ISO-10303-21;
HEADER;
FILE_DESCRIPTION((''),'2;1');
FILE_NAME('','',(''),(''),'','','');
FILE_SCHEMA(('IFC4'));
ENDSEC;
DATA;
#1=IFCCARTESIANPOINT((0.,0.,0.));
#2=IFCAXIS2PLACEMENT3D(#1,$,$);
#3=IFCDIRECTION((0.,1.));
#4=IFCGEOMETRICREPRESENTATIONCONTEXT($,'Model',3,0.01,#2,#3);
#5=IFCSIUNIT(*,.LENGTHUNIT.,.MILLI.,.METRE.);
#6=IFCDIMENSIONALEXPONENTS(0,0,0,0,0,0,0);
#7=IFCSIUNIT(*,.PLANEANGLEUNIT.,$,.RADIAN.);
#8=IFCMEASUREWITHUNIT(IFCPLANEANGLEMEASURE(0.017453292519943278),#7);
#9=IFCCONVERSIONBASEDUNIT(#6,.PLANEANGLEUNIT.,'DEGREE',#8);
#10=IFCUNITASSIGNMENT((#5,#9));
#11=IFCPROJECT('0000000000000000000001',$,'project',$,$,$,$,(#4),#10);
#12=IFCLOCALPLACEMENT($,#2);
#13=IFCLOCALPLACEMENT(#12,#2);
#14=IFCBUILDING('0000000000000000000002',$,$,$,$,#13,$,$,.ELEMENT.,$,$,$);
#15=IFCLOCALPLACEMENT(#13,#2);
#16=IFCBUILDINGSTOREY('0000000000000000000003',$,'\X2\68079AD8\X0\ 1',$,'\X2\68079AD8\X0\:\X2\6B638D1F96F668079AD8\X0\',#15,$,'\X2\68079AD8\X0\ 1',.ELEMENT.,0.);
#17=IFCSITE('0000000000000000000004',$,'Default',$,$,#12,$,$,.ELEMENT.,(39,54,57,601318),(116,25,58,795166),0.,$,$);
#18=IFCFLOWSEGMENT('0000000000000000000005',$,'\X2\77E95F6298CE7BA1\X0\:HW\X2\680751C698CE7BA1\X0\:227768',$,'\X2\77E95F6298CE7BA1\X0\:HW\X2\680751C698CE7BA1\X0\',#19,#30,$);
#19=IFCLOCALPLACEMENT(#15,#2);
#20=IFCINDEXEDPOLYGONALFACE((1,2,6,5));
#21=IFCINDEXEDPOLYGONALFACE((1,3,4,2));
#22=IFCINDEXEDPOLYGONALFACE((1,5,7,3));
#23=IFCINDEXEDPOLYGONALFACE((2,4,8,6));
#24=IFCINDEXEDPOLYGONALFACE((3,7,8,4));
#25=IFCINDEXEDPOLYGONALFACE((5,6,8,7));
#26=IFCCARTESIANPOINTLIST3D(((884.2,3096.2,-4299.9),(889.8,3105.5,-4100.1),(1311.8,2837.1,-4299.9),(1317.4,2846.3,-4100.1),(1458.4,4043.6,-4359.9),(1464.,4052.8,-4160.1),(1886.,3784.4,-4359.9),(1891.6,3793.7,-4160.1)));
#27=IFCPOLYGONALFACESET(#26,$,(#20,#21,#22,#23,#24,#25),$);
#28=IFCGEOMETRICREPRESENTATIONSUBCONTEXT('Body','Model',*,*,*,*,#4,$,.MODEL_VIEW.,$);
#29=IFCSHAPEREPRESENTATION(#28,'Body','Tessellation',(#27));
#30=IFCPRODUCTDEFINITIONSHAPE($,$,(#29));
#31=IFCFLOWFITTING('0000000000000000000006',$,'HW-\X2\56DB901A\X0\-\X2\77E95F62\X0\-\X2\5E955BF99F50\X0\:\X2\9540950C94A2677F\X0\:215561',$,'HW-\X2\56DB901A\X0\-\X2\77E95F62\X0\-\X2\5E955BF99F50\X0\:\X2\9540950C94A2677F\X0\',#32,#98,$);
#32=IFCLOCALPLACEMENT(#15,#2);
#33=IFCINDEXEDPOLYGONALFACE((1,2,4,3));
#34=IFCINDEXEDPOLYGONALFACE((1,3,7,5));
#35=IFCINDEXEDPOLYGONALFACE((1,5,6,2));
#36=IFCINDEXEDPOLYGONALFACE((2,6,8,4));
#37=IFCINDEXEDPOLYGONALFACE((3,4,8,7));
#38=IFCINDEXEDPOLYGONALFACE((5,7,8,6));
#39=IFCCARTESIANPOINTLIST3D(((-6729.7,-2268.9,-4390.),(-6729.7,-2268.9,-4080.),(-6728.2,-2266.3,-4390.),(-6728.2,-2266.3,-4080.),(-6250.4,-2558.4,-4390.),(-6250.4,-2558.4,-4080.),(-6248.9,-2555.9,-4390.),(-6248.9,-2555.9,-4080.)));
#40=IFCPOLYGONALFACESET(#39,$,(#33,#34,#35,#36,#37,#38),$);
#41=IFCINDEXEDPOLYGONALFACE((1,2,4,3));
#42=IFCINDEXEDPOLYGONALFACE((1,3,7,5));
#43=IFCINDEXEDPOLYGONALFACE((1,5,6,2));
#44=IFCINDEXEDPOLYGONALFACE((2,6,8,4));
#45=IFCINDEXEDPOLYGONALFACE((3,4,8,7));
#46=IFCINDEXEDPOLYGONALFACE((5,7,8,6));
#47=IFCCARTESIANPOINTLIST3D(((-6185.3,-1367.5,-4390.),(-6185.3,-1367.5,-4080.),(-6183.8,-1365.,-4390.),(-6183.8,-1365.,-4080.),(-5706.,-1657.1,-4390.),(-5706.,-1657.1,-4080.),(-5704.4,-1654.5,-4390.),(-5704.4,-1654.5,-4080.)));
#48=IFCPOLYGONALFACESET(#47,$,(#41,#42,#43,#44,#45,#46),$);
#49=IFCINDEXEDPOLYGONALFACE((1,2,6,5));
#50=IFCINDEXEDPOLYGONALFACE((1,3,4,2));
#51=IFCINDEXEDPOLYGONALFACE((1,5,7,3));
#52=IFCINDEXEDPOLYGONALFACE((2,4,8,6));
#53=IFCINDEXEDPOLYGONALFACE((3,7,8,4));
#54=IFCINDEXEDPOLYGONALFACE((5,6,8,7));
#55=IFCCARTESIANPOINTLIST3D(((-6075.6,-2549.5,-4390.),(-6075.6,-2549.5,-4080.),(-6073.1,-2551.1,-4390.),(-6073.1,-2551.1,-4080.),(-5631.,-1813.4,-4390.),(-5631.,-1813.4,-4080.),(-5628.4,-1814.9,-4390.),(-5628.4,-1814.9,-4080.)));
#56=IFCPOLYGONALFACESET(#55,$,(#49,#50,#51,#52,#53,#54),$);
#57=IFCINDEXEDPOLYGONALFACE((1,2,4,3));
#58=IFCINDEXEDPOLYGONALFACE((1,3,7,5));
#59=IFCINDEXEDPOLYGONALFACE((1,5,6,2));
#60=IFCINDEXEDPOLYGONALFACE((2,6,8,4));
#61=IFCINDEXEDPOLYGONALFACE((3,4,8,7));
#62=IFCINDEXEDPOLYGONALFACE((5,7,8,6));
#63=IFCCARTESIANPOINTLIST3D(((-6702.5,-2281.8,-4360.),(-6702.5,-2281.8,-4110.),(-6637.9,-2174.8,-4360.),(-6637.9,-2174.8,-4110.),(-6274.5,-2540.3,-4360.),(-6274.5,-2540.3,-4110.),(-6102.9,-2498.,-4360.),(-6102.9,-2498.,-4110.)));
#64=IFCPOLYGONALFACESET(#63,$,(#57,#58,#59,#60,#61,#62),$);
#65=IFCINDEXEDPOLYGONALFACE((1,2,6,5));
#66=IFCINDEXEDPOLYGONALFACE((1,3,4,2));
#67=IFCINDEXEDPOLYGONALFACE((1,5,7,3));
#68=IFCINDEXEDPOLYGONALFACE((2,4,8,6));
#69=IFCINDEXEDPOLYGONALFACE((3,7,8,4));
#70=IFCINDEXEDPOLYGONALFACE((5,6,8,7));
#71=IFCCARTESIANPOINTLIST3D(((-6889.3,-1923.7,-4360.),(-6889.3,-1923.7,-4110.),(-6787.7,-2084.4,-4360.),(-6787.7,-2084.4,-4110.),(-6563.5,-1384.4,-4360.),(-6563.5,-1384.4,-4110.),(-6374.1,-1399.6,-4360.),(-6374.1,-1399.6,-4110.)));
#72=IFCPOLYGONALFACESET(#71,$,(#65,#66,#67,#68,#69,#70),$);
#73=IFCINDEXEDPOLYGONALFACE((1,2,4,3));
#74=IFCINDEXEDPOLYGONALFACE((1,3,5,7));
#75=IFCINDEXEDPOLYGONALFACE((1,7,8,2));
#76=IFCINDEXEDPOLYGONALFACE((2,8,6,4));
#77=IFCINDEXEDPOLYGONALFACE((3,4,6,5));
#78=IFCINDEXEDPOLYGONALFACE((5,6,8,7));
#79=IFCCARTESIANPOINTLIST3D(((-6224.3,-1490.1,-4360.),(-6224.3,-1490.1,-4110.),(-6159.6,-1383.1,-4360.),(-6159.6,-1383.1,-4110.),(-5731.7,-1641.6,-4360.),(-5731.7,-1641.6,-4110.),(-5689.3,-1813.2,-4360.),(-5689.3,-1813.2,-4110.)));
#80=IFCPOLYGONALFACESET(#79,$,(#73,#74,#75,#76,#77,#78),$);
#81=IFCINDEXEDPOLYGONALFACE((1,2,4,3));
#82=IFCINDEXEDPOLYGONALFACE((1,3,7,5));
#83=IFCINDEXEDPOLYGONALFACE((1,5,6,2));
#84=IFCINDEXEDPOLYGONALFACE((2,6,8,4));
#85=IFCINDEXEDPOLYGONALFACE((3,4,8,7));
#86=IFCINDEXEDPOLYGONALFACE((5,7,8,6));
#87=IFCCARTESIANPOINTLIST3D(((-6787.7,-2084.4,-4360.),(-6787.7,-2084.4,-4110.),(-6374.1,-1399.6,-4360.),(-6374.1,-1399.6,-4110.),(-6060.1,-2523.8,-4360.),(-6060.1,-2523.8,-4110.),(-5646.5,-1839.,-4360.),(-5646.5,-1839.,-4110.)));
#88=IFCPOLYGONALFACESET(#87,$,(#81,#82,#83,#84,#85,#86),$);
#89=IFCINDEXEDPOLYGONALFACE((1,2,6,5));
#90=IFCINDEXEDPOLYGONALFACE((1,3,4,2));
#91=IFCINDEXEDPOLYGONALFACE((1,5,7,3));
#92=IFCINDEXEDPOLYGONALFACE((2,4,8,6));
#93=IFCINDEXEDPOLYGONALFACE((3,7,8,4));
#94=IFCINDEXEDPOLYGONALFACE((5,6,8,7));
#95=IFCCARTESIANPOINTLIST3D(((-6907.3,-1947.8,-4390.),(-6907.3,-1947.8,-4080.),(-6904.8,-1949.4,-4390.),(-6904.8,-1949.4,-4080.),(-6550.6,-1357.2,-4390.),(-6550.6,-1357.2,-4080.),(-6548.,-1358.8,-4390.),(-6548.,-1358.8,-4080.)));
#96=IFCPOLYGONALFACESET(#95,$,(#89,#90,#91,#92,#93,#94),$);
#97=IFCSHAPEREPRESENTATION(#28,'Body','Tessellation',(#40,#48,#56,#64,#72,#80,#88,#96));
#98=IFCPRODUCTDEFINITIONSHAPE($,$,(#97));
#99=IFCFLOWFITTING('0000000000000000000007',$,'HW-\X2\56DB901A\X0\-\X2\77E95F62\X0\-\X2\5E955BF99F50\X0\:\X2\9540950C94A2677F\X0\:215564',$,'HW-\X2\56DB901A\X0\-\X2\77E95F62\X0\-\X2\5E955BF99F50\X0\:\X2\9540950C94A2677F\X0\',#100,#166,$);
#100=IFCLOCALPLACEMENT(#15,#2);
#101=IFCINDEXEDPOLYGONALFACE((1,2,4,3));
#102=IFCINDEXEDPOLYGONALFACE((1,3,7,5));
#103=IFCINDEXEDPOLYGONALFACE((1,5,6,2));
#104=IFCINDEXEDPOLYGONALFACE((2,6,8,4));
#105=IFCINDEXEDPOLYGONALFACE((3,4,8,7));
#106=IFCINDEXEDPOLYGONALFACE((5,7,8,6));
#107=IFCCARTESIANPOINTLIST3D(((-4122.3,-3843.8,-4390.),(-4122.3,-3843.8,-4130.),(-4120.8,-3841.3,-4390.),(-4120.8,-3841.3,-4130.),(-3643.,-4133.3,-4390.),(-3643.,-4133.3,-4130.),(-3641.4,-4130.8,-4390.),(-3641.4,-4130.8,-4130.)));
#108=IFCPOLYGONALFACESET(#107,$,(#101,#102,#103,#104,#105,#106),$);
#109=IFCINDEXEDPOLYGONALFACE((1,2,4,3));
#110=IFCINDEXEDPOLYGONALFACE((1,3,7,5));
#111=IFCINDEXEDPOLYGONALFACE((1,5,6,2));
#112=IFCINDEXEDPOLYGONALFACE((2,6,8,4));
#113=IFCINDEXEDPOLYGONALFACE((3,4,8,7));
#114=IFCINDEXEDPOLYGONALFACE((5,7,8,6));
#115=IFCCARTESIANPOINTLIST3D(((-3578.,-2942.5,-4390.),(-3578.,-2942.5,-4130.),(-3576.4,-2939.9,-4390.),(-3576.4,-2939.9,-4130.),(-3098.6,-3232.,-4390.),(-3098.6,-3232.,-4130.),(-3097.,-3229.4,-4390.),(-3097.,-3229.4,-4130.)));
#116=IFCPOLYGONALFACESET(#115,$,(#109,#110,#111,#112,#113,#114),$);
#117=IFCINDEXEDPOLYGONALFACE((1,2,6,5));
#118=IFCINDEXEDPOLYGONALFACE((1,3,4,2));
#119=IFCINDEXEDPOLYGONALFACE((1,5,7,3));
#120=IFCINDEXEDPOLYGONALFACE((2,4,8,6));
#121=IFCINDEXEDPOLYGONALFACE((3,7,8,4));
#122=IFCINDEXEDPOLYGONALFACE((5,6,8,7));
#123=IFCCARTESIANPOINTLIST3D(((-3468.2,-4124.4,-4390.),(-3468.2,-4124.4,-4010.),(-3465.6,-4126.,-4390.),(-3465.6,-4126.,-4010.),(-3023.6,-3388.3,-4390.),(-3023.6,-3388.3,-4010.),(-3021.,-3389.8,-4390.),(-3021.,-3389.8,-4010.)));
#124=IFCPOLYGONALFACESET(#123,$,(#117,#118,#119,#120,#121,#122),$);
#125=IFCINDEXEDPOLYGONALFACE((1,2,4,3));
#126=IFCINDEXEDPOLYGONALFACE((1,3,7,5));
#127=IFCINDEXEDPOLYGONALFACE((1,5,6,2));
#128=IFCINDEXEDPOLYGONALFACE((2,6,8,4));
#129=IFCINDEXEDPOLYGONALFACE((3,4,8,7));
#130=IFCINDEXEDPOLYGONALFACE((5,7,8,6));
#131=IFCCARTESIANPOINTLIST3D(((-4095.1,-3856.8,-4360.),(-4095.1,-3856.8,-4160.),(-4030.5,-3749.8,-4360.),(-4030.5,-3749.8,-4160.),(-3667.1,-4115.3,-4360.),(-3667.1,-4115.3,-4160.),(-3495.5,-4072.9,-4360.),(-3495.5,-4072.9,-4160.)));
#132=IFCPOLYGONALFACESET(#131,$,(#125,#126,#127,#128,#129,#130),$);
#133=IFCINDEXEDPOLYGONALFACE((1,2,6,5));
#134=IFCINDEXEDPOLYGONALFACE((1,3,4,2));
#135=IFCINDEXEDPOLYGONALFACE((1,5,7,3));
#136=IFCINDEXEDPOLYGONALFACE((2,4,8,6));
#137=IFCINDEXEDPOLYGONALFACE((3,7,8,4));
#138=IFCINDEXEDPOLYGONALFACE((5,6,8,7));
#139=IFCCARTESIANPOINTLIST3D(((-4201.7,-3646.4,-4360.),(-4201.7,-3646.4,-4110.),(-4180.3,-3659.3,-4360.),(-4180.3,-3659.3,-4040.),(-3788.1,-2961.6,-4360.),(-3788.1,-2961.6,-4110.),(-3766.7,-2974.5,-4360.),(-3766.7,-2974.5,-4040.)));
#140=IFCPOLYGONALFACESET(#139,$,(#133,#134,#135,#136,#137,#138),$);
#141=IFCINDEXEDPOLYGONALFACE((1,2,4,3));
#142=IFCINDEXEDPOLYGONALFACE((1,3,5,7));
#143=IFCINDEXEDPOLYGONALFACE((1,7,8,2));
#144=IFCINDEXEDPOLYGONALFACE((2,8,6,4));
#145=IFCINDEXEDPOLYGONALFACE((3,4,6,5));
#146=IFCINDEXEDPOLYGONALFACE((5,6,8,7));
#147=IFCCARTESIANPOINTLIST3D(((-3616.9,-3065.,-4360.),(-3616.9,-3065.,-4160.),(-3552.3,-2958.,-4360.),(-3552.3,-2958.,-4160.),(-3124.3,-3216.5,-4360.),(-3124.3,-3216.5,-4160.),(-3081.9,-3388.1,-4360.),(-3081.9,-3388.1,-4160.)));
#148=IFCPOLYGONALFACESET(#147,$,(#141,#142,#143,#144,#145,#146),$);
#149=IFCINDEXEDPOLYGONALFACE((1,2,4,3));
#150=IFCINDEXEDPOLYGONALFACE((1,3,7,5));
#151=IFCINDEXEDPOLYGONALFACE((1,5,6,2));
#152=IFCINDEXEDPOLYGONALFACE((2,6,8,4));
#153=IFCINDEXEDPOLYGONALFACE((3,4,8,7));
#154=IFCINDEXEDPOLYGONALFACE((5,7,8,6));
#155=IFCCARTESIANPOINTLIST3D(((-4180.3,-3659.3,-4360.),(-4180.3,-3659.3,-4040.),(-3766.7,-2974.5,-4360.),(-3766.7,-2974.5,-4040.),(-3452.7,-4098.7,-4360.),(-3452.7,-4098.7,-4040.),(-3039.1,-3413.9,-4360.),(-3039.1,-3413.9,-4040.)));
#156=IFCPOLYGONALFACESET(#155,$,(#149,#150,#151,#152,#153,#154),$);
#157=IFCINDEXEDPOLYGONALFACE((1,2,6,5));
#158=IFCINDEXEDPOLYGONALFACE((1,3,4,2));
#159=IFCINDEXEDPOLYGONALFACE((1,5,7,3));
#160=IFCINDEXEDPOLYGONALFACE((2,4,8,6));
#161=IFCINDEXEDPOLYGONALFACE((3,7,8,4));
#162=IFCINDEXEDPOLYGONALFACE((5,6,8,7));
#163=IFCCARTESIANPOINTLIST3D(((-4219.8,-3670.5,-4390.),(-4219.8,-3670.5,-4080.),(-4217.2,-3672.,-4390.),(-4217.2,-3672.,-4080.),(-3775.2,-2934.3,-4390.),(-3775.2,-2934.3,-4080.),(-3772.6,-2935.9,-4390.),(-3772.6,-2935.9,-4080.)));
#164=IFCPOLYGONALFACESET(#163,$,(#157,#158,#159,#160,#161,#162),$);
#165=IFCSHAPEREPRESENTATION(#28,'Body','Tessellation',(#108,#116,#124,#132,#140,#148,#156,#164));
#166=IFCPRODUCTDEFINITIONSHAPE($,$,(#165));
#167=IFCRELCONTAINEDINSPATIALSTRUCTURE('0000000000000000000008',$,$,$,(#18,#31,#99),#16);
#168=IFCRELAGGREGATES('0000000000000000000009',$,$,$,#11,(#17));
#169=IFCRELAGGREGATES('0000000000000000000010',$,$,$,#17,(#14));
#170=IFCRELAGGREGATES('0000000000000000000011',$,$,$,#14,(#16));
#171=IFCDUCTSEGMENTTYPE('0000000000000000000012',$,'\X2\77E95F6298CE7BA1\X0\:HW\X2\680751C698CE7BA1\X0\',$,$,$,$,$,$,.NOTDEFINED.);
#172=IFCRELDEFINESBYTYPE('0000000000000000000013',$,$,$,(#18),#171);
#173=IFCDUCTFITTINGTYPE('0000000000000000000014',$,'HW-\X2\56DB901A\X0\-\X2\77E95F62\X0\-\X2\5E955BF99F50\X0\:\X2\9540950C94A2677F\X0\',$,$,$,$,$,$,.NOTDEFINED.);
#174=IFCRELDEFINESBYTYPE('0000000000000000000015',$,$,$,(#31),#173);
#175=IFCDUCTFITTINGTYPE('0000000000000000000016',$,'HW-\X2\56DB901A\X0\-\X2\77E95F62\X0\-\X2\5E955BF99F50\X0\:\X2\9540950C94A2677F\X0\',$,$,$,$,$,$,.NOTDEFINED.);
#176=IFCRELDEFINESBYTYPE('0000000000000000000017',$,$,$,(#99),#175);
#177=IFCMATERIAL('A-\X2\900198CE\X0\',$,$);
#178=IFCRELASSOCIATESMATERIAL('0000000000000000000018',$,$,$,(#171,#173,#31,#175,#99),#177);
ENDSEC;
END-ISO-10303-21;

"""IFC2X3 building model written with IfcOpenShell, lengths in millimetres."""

from ifc_helpers import new_model, entity, si_unit, converted_unit, direction, frame, frame_2d, origin, origin_2d_with_axis, place, context, subcontext, project, spatial, polyline, rectangle, outline, extrude, source, transform, mapped, material, type_object, type_shapes, element, save


model = new_model("IFC2X3")

# Units and contexts
model_context = context("Model", 3, precision=0.01, world=origin(), true_north=direction((0.0, 1.0)))
body_context = subcontext(model_context, "Body", "Model", "MODEL_VIEW")
ifc_project = project(units=[si_unit("LENGTHUNIT", "METRE", prefix="MILLI"), converted_unit("PLANEANGLEUNIT", "DEGREE", entity("IfcPlaneAngleMeasure", 0.017453292519943278), si_unit("PLANEANGLEUNIT", "RADIAN"), dimensions=[0, 0, 0, 0, 0, 0, 0])], contexts=[model_context])

# Site, building, storey
site_placement = place(None, origin())
site = spatial("IfcSite", under=ifc_project, at=site_placement, Name="Default", CompositionType="ELEMENT", RefLatitude=(39, 54, 57, 601318), RefLongitude=(116, 25, 58, 795166), RefElevation=0.0)
building_placement = place(site_placement, origin())
building = spatial("IfcBuilding", under=site, at=building_placement, CompositionType="ELEMENT")
storey_placement = place(building_placement, origin())
storey = spatial("IfcBuildingStorey", under=building, at=storey_placement, Name="标高 1", ObjectType="标高:正负零标高", LongName="标高 1", CompositionType="ELEMENT", Elevation=0.0)

# Flow segment
ifc_material = material(Name="A-送风")
duct_segment_type = type_object("IfcDuctSegmentType", Name="矩形风管:HW标准风管", PredefinedType="NOTDEFINED", material=ifc_material)
flow_segment_1_placement = place(storey_placement, origin())
element("IfcFlowSegment", 1, at=flow_segment_1_placement, inside=storey, type_object=duct_segment_type, Name="矩形风管:HW标准风管:227768", ObjectType="矩形风管:HW标准风管", context=body_context, shape_type="SweptSolid", body=[
    extrude(rectangle(XDim=200.0, YDim=500.0, at=frame_2d((0.0, 0.0), x_axis=(0.0, 1.0))), frame((1100.8, 2971.3, -4200.0), z_axis=(0.51756, 0.853936, -0.054083), x_axis=(-0.855188, 0.518318, 0.0)), (0.0, 0.0, 1.0), 1109.4),
])

# Flow fittings
duct_fitting_type_1 = type_object("IfcDuctFittingType", Name="HW-四通-矩形-底对齐:镀锌钢板", PredefinedType="NOTDEFINED", material=ifc_material)
shared_shape_1 = source(origin(), body_context, "Body", "SweptSolid", [
    extrude(rectangle(XDim=560.0, YDim=3.0, at=origin_2d_with_axis()), frame((0.0, 526.5, -155.0), z_axis=(0.0, 0.0, 1.0), x_axis=(-1.0, 0.0, 0.0)), (0.0, 0.0, 1.0), 310.0),
    extrude(rectangle(XDim=560.0, YDim=3.0, at=frame_2d((0.0, 0.0), x_axis=(1.0, 0.0))), frame((0.0, -526.5, -155.0), z_axis=(0.0, 0.0, 1.0), x_axis=(-1.0, 0.0, 0.0)), (0.0, 0.0, 1.0), 310.0),
    extrude(rectangle(XDim=860.0, YDim=3.0, at=frame_2d((0.0, 0.0), x_axis=(1.0, 0.0))), frame((-426.5, 0.0, -155.0), z_axis=(0.0, 0.0, 1.0), x_axis=(0.0, 1.0, 0.0)), (0.0, 0.0, 1.0), 310.0),
    extrude(outline(polyline([(110.5, -198.9), (287.3, -198.9), (-154.7, 243.1), (-243.1, 154.7), (110.5, -198.9)])), frame((-31.2, 462.5, -125.0), z_axis=(0.0, 0.0, 1.0), x_axis=(-0.707107, -0.707107, 0.0)), (0.0, 0.0, 1.0), 250.0),
    extrude(outline(polyline([(64.8, -319.8), (254.9, -319.8), (-102.9, 395.8), (-216.9, 243.7), (64.8, -319.8)])), frame((510.0, 0.0, -125.0), z_axis=(0.0, 0.0, 1.0), x_axis=(-0.894427, 0.447214, 0.0)), (0.0, 0.0, 1.0), 250.0),
    extrude(outline(polyline([(-62.5, -281.2), (62.5, -281.2), (62.5, 343.8), (-62.5, 218.7), (-62.5, -281.2)])), frame((-31.3, -462.5, -125.0), z_axis=(0.0, 0.0, 1.0), x_axis=(0.0, 1.0, 0.0)), (0.0, 0.0, 1.0), 250.0),
    extrude(rectangle(XDim=850.0, YDim=800.0, at=origin_2d_with_axis()), frame((0.0, 0.0, -125.0), z_axis=(0.0, 0.0, 1.0), x_axis=(-1.0, 0.0, 0.0)), (0.0, 0.0, 1.0), 250.0),
    extrude(rectangle(XDim=690.0, YDim=3.0, at=frame_2d((0.0, 0.0), x_axis=(1.0, 0.0))), frame((596.5, 0.0, -155.0), z_axis=(0.0, 0.0, 1.0), x_axis=(0.0, 1.0, 0.0)), (0.0, 0.0, 1.0), 310.0),
])
type_shapes(duct_fitting_type_1, [shared_shape_1])
flow_fitting_1_placement = place(storey_placement, frame((-6217.1, -1961.7, -4235.0), z_axis=(0.0, 0.0, 1.0), x_axis=(-0.855971, 0.517024, 0.0)))
element("IfcFlowFitting", 2, at=flow_fitting_1_placement, inside=storey, type_object=duct_fitting_type_1, material=ifc_material, Name="HW-四通-矩形-底对齐:镀锌钢板:215561", ObjectType="HW-四通-矩形-底对齐:镀锌钢板", context=body_context, shape_type="MappedRepresentation", body=[
    mapped(shared_shape_1, transform((0.0, 0.0, 0.0), scale=1.0)),
])
duct_fitting_type_2 = type_object("IfcDuctFittingType", Name="HW-四通-矩形-底对齐:镀锌钢板", PredefinedType="NOTDEFINED", material=ifc_material)
shared_shape_2 = source(origin(), body_context, "Body", "SweptSolid", [
    extrude(rectangle(XDim=560.0, YDim=3.0, at=origin_2d_with_axis()), frame((0.0, 526.5, -190.0), z_axis=(0.0, 0.0, 1.0), x_axis=(-1.0, 0.0, 0.0)), (0.0, 0.0, 1.0), 260.0),
    extrude(rectangle(XDim=560.0, YDim=3.0, at=frame_2d((0.0, 0.0), x_axis=(1.0, 0.0))), frame((0.0, -526.5, -190.0), z_axis=(0.0, 0.0, 1.0), x_axis=(-1.0, 0.0, 0.0)), (0.0, 0.0, 1.0), 260.0),
    extrude(rectangle(XDim=860.0, YDim=3.0, at=frame_2d((0.0, 0.0), x_axis=(1.0, 0.0))), frame((-426.5, 0.0, -190.0), z_axis=(0.0, 0.0, 1.0), x_axis=(0.0, 1.0, 0.0)), (0.0, 0.0, 1.0), 380.0),
    extrude(outline(polyline([(110.5, -198.9), (287.3, -198.9), (-154.7, 243.1), (-243.1, 154.7), (110.5, -198.9)])), frame((-31.2, 462.5, -160.0), z_axis=(0.0, 0.0, 1.0), x_axis=(-0.707107, -0.707107, 0.0)), (0.0, 0.0, 1.0), 200.0),
    extrude(outline(polyline([(-12.5, -142.5), (12.5, -142.5), (12.5, 177.5), (-12.5, 107.5), (-12.5, -142.5)])), frame((437.5, -400.0, -17.5), z_axis=(0.0, 1.0, 0.0), x_axis=(-1.0, 0.0, 0.0)), (0.0, 0.0, 1.0), 800.0),
    extrude(outline(polyline([(-62.5, -281.2), (62.5, -281.2), (62.5, 343.8), (-62.5, 218.7), (-62.5, -281.2)])), frame((-31.3, -462.5, -160.0), z_axis=(0.0, 0.0, 1.0), x_axis=(0.0, 1.0, 0.0)), (0.0, 0.0, 1.0), 200.0),
    extrude(rectangle(XDim=850.0, YDim=800.0, at=origin_2d_with_axis()), frame((0.0, 0.0, -160.0), z_axis=(0.0, 0.0, 1.0), x_axis=(-1.0, 0.0, 0.0)), (0.0, 0.0, 1.0), 320.0),
    extrude(rectangle(XDim=860.0, YDim=3.0, at=frame_2d((0.0, 0.0), x_axis=(1.0, 0.0))), frame((451.5, 0.0, -190.0), z_axis=(0.0, 0.0, 1.0), x_axis=(0.0, 1.0, 0.0)), (0.0, 0.0, 1.0), 310.0),
])
type_shapes(duct_fitting_type_2, [shared_shape_2])
for number, where, z_axis, x_axis, name in (
    (3, (-3609.7, -3536.6, -4200.0), (0.0, 0.0, 1.0), (-0.85599, 0.516993, 0.0), "HW-四通-矩形-底对齐:镀锌钢板:215564"),
):
    element("IfcFlowFitting", number, at=place(storey_placement, frame(where, z_axis=z_axis, x_axis=x_axis)), inside=storey, type_object=duct_fitting_type_2, material=ifc_material, Name=name, ObjectType="HW-四通-矩形-底对齐:镀锌钢板", context=body_context, shape_type="MappedRepresentation", body=[
        mapped(shared_shape_2, transform((0.0, 0.0, 0.0), scale=1.0)),
    ])

save(model, "model.ifc")
